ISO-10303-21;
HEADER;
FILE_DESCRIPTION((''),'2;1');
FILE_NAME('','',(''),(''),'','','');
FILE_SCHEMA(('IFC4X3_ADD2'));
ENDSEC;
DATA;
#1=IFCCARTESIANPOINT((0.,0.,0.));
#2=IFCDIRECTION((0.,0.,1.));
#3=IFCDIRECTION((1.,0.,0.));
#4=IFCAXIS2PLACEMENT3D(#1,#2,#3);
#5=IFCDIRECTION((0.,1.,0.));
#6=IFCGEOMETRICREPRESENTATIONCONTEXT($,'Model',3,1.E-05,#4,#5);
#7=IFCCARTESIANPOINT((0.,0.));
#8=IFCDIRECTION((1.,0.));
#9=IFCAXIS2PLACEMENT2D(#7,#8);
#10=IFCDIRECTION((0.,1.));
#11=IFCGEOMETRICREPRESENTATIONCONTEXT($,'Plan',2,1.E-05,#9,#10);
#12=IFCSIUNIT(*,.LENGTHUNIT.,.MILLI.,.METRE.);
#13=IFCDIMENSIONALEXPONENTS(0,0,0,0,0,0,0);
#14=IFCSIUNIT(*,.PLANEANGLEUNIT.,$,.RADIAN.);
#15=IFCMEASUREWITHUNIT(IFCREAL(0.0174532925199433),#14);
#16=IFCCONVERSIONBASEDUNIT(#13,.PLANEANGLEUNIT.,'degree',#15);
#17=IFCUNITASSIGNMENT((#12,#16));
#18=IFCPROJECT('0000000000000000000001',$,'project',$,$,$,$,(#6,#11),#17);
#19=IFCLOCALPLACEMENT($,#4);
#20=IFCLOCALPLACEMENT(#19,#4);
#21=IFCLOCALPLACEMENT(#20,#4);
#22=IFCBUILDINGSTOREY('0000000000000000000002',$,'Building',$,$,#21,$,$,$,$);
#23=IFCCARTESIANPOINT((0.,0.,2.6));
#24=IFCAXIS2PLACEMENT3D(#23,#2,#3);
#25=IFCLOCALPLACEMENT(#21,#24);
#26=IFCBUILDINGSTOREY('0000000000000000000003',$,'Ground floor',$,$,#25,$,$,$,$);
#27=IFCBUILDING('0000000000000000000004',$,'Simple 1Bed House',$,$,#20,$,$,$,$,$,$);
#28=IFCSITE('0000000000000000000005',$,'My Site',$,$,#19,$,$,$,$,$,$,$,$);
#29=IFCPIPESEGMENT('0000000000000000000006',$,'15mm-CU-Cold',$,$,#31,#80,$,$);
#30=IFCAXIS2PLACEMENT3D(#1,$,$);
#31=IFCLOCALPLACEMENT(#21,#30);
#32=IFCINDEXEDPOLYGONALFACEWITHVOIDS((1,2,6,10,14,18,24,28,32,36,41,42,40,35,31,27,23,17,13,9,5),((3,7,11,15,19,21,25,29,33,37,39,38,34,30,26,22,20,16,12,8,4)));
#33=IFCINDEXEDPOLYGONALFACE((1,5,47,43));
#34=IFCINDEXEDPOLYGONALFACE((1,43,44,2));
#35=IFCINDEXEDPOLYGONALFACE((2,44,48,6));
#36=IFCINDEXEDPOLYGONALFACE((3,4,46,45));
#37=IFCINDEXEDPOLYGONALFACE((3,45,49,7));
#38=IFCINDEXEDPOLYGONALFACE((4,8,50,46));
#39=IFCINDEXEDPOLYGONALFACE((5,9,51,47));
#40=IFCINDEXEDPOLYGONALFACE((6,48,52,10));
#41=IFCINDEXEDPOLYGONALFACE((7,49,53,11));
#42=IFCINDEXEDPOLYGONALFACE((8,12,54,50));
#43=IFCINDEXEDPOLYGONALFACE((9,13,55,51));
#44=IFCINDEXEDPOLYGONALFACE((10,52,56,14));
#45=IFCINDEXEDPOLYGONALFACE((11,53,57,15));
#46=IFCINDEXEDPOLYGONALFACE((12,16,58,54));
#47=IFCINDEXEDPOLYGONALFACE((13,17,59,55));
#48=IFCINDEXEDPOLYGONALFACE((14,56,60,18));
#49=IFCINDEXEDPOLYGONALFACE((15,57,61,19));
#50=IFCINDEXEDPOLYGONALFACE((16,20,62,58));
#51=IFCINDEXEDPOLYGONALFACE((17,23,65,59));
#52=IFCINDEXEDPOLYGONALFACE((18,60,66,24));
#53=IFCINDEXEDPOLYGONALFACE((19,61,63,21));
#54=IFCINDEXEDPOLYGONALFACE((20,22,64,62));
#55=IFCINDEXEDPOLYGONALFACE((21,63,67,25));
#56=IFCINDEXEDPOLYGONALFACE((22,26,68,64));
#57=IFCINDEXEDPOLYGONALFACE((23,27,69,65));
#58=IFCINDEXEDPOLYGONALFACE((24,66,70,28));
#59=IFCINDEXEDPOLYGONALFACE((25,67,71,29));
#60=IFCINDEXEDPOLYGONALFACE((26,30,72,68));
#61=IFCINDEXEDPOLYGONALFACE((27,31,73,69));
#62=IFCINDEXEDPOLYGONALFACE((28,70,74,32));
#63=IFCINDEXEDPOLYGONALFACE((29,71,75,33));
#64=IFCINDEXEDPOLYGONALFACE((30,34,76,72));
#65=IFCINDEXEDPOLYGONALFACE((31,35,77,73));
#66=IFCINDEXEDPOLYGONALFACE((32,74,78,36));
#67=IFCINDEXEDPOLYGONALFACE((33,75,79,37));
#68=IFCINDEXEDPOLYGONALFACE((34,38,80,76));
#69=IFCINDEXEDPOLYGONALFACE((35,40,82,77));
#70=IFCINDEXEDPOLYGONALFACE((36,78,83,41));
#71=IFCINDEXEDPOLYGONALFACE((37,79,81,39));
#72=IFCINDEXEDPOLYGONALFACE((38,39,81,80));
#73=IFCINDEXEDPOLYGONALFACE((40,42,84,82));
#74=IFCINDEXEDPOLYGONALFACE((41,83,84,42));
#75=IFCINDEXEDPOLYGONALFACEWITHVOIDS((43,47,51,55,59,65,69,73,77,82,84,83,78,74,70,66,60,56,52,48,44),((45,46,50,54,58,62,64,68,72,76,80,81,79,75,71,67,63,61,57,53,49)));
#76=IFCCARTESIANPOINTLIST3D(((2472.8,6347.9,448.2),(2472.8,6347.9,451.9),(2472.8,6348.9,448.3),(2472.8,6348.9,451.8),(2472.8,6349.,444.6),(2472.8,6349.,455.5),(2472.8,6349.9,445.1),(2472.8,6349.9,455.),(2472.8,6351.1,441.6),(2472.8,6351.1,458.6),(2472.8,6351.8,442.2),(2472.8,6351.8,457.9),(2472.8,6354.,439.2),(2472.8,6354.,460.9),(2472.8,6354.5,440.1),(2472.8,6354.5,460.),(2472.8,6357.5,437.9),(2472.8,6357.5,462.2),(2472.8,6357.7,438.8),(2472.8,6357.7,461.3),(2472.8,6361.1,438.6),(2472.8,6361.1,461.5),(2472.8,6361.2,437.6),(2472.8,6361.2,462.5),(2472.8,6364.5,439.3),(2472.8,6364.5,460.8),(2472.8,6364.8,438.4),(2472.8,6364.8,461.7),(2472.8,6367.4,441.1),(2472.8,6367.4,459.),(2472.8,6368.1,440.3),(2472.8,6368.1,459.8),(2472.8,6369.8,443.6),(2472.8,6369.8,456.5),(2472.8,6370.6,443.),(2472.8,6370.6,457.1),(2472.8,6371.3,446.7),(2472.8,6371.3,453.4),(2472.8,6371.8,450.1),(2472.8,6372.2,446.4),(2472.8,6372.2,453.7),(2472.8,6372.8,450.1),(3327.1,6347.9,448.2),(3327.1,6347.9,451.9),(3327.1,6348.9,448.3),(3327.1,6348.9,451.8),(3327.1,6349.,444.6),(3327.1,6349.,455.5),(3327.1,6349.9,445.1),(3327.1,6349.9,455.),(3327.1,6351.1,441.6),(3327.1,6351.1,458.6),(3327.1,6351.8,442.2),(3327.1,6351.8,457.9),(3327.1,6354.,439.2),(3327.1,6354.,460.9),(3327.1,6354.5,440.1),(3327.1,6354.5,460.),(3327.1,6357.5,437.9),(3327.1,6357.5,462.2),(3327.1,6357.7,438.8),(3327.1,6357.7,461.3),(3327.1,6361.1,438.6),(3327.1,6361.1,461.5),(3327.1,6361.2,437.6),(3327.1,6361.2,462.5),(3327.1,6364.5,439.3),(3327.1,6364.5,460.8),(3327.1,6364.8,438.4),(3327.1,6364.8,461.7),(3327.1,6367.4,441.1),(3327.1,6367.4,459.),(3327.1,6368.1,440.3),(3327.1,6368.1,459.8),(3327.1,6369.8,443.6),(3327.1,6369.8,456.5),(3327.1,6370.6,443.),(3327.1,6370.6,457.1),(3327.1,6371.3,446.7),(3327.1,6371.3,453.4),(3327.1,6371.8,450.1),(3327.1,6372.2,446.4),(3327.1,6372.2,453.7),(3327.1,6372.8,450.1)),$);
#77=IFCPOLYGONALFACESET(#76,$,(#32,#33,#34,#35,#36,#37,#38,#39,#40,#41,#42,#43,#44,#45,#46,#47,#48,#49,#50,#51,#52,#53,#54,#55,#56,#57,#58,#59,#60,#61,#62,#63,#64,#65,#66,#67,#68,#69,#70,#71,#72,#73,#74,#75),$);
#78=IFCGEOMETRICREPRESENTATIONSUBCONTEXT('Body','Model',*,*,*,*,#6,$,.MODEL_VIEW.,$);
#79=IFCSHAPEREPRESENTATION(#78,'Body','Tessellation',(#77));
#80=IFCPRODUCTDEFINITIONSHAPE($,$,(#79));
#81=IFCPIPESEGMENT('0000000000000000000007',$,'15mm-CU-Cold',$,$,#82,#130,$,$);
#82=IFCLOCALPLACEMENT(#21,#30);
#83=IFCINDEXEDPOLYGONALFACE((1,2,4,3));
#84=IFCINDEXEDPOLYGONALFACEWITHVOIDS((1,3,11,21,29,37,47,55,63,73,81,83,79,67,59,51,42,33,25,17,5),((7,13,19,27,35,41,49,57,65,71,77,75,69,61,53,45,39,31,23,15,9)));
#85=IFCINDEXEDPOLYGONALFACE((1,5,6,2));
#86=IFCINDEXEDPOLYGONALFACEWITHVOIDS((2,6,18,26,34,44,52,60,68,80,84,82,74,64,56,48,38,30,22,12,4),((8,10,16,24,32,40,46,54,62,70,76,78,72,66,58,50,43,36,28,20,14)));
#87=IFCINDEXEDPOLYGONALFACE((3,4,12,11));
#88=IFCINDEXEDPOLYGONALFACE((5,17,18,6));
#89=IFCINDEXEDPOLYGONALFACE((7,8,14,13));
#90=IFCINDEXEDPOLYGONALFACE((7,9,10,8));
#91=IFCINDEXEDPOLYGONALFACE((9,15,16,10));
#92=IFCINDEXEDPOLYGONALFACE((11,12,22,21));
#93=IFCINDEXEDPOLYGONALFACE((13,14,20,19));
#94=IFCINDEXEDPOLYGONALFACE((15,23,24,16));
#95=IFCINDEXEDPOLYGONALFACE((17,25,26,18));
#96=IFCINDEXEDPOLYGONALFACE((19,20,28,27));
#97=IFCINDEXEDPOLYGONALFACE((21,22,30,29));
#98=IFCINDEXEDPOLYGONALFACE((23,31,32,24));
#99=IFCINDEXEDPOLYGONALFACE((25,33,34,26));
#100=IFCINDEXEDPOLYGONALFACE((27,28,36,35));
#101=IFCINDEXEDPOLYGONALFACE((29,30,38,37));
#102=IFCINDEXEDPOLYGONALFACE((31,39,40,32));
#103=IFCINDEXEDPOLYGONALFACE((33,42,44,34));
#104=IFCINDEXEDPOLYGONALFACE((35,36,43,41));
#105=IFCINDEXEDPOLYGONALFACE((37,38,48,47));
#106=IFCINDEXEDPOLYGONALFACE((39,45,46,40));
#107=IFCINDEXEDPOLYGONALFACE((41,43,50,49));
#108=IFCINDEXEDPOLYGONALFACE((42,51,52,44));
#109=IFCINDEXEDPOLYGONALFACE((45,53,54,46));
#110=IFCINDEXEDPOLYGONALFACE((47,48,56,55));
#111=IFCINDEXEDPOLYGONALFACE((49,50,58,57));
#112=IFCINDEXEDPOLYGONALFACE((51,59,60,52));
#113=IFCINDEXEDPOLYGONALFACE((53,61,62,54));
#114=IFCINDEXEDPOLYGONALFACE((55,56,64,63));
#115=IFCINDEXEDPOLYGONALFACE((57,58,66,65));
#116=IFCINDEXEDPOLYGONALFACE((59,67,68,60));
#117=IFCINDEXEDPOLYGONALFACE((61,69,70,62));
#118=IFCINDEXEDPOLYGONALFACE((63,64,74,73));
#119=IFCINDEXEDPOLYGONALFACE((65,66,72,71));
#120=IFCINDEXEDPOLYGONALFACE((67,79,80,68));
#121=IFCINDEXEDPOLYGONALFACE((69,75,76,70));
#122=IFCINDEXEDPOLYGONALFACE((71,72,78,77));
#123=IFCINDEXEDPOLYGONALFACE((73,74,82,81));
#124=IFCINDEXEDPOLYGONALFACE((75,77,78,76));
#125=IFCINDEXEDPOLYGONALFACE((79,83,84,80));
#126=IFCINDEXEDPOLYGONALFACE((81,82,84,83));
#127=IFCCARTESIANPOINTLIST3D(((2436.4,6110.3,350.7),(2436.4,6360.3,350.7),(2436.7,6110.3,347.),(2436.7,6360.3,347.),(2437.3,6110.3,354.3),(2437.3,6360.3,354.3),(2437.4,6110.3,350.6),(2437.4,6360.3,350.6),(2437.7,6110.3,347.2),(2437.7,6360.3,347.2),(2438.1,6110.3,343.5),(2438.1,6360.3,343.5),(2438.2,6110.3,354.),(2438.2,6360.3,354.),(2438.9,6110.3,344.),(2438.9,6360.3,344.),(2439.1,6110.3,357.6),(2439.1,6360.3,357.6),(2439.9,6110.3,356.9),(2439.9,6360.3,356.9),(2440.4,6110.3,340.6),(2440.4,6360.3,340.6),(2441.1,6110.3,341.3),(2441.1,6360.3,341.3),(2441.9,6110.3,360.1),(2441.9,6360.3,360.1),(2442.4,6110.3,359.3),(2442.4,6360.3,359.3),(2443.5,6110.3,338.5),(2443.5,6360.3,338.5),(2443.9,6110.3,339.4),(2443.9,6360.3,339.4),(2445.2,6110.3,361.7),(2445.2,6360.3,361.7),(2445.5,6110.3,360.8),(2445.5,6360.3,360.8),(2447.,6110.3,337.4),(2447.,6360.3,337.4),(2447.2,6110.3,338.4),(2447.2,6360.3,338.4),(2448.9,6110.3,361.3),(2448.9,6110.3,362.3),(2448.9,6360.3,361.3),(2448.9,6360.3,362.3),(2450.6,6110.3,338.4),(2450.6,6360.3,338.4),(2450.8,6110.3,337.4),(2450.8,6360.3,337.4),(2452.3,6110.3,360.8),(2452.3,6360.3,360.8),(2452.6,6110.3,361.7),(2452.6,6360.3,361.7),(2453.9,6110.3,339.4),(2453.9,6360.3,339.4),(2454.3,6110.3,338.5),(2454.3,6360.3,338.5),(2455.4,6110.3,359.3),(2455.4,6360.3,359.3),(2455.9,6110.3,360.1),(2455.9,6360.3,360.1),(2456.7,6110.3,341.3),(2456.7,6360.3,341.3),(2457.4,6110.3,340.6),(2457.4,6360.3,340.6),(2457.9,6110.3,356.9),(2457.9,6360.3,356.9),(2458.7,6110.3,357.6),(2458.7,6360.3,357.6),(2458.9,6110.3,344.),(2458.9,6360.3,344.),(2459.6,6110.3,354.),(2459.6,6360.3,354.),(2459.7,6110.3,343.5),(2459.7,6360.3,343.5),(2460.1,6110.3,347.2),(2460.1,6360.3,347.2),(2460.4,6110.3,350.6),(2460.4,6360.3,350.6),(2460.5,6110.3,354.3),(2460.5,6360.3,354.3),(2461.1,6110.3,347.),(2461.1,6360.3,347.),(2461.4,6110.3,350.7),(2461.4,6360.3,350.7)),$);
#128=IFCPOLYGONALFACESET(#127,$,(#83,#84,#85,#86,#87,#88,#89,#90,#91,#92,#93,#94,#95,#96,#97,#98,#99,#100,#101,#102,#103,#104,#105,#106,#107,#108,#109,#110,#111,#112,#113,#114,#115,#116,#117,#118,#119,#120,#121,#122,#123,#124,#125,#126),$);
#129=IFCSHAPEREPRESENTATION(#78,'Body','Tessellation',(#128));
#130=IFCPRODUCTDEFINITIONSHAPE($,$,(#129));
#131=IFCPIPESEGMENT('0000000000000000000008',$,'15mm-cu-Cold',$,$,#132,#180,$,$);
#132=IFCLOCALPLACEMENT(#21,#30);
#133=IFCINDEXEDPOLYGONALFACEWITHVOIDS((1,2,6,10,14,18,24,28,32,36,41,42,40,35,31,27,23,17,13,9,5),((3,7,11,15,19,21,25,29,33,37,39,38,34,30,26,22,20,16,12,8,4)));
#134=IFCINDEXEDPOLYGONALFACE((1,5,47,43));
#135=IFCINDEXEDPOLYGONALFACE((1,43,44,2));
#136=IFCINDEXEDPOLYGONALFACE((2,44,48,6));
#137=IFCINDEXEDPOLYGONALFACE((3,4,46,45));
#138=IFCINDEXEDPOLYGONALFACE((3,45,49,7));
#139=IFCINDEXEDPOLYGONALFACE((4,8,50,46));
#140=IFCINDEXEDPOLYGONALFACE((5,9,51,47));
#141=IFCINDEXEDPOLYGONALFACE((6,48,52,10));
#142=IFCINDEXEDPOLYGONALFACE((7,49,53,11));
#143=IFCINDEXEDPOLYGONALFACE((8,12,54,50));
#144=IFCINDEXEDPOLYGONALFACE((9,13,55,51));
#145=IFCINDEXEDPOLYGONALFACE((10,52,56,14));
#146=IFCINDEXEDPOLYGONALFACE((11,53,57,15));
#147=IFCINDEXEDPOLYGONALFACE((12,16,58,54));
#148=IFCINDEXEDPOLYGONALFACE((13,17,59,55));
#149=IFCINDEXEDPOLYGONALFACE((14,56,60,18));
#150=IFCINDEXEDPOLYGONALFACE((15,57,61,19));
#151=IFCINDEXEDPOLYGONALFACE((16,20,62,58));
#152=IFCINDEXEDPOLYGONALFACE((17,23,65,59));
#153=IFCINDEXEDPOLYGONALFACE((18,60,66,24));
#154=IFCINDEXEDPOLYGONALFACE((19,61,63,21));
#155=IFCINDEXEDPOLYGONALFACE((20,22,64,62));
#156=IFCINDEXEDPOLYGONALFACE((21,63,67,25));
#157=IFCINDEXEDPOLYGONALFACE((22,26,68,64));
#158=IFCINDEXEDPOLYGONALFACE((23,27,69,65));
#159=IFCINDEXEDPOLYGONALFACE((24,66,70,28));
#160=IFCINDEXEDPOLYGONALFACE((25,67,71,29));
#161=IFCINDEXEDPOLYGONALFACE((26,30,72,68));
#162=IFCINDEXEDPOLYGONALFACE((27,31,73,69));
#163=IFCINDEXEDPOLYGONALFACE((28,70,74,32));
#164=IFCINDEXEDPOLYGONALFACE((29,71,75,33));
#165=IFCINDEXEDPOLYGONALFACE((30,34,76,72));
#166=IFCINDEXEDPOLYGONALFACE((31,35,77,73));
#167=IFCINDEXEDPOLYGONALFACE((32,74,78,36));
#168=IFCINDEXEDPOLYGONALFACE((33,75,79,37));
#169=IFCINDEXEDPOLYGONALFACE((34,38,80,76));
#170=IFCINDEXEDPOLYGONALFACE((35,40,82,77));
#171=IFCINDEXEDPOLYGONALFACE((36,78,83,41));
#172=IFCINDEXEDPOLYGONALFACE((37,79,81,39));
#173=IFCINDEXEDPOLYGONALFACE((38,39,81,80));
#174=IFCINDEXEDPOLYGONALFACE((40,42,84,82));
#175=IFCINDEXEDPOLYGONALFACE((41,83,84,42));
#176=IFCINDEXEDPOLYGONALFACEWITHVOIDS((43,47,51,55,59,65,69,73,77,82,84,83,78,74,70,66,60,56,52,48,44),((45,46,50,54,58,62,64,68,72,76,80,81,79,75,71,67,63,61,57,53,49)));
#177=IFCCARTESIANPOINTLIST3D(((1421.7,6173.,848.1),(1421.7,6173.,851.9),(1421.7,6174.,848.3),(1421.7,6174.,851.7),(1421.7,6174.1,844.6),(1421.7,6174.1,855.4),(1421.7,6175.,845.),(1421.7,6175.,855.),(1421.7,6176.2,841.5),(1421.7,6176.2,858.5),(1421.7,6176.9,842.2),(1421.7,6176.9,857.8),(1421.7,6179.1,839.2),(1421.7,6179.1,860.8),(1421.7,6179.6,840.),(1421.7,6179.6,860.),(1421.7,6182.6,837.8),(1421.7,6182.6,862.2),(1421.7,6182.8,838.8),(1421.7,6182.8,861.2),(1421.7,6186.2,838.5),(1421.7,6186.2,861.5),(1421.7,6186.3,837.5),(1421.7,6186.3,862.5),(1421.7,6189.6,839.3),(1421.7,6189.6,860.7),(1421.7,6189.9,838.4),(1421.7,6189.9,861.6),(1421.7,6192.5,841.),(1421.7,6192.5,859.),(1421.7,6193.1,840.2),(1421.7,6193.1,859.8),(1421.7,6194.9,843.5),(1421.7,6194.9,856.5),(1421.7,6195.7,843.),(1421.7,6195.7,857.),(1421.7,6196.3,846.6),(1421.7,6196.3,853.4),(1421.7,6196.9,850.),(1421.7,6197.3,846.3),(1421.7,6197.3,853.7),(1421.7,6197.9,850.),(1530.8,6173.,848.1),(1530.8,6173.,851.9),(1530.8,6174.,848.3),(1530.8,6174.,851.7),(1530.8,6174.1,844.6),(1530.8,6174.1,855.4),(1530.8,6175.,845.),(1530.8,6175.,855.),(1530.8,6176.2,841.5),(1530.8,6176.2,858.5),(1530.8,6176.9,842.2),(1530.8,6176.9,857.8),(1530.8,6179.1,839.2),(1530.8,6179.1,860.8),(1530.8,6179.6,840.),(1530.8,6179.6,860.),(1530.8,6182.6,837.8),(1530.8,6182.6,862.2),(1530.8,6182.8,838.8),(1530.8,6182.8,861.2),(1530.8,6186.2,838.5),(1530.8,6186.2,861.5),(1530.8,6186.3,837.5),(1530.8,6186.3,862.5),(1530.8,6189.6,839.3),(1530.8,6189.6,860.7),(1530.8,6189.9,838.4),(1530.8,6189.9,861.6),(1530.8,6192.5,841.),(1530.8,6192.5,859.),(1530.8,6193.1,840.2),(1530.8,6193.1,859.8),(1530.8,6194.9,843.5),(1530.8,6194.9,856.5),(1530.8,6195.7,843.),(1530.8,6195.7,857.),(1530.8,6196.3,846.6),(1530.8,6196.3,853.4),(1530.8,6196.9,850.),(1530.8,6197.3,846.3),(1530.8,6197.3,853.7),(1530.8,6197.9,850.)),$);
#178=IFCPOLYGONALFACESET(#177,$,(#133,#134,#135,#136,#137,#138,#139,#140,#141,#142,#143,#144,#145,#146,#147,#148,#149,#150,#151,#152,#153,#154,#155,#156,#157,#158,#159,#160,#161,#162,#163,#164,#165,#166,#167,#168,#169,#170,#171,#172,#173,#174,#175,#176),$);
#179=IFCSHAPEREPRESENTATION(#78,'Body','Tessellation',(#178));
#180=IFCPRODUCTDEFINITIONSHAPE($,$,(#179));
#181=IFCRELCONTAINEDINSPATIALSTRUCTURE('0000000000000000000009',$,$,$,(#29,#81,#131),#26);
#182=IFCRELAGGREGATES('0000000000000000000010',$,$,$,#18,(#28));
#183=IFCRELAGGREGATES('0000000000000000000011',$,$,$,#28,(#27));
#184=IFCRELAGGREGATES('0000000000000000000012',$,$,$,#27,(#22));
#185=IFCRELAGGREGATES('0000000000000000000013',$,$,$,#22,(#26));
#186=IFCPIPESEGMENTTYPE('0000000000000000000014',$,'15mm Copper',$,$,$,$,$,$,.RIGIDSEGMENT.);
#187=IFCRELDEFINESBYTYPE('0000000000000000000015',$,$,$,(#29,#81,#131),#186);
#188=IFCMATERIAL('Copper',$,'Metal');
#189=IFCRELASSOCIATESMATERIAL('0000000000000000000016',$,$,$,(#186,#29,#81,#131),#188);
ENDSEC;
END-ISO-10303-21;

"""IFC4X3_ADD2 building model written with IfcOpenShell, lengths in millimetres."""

from ifc_helpers import new_model, entity, si_unit, converted_unit, direction, frame, origin_with_axes, origin_2d_with_axis, place, context, subcontext, project, spatial, hollow_circle, extrude, material, material_profile, profile_set, profile_usage, type_object, element, save


model = new_model("IFC4X3_ADD2")

# Units and contexts
model_context = context("Model", 3, precision=1e-05, world=origin_with_axes(), true_north=direction((0.0, 1.0, 0.0)))
plan_context = context("Plan", 2, precision=1e-05, world=origin_2d_with_axis(), true_north=direction((0.0, 1.0)))
body_context_1 = subcontext(model_context, "Body", "Model", "MODEL_VIEW")
ifc_project = project(units=[si_unit("LENGTHUNIT", "METRE", prefix="MILLI"), converted_unit("PLANEANGLEUNIT", "degree", entity("IfcReal", 0.0174532925199433), si_unit("PLANEANGLEUNIT", "RADIAN"), dimensions=[0, 0, 0, 0, 0, 0, 0])], contexts=[model_context, plan_context])

# Site, building, storeys
site_placement = place(None, origin_with_axes())
site = spatial("IfcSite", under=ifc_project, at=site_placement, Name="My Site")
building_placement = place(site_placement, origin_with_axes())
building = spatial("IfcBuilding", under=site, at=building_placement, Name="Simple 1Bed House")
storey_1_placement = place(building_placement, origin_with_axes())
storey_1 = spatial("IfcBuildingStorey", under=building, at=storey_1_placement, Name="Building")
storey_2_placement = place(storey_1_placement, frame((0.0, 0.0, 2.6), z_axis=(0.0, 0.0, 1.0), x_axis=(1.0, 0.0, 0.0)))
storey_2 = spatial("IfcBuildingStorey", under=storey_1, at=storey_2_placement, Name="Ground floor")

# Pipe segments
ifc_material_1 = material(Name="Copper", Category="Metal")
ifc_material_profile_1 = material_profile(ifc_material_1, hollow_circle(Radius=12.5, WallThickness=1.0))
ifc_profile_set_1 = profile_set([ifc_material_profile_1])
pipe_segment_type_1 = type_object("IfcPipeSegmentType", Name="15mm Copper", PredefinedType="RIGIDSEGMENT", material=ifc_profile_set_1)
ifc_profile_usage_1 = profile_usage(ifc_profile_set_1, cardinal=5)
pipe_segment_1_placement = place(storey_2_placement, frame((2472.8, 6360.3, 447.5), z_axis=(1.0, 0.0, 0.0), x_axis=(0.0, 1.0, 0.0)))
element("IfcPipeSegment", 1, at=pipe_segment_1_placement, inside=storey_2, type_object=pipe_segment_type_1, material=ifc_profile_usage_1, Name="15mm-CU-Cold", context=body_context_1, shape_type="SweptSolid", body=[
    extrude(hollow_circle(Radius=12.5, WallThickness=1.0), origin_with_axes(), (0.0, 0.0, 1.0), 854.3),
])
ifc_profile_usage_2 = profile_usage(ifc_profile_set_1, cardinal=5)
pipe_segment_2_placement = place(storey_2_placement, frame((2448.9, 6360.3, 347.2), z_axis=(0.0, -1.0, 0.0), x_axis=(0.0, 0.0, 1.0)))
element("IfcPipeSegment", 2, at=pipe_segment_2_placement, inside=storey_2, type_object=pipe_segment_type_1, material=ifc_profile_usage_2, Name="15mm-CU-Cold", context=body_context_1, shape_type="SweptSolid", body=[
    extrude(hollow_circle(Radius=12.5, WallThickness=1.0), origin_with_axes(), (0.0, 0.0, 1.0), 250.0),
])
ifc_profile_usage_3 = profile_usage(ifc_profile_set_1, cardinal=5)
pipe_segment_3_placement = place(storey_2_placement, frame((1530.8, 6185.4, 847.4), z_axis=(-1.0, 0.0, 0.0), x_axis=(0.0, 1.0, 0.0)))
element("IfcPipeSegment", 3, at=pipe_segment_3_placement, inside=storey_2, type_object=pipe_segment_type_1, material=ifc_profile_usage_3, Name="15mm-cu-Cold", context=body_context_1, shape_type="SweptSolid", body=[
    extrude(hollow_circle(Radius=12.5, WallThickness=1.0), origin_with_axes(), (0.0, 0.0, 1.0), 109.1),
])

save(model, "model.ifc")
